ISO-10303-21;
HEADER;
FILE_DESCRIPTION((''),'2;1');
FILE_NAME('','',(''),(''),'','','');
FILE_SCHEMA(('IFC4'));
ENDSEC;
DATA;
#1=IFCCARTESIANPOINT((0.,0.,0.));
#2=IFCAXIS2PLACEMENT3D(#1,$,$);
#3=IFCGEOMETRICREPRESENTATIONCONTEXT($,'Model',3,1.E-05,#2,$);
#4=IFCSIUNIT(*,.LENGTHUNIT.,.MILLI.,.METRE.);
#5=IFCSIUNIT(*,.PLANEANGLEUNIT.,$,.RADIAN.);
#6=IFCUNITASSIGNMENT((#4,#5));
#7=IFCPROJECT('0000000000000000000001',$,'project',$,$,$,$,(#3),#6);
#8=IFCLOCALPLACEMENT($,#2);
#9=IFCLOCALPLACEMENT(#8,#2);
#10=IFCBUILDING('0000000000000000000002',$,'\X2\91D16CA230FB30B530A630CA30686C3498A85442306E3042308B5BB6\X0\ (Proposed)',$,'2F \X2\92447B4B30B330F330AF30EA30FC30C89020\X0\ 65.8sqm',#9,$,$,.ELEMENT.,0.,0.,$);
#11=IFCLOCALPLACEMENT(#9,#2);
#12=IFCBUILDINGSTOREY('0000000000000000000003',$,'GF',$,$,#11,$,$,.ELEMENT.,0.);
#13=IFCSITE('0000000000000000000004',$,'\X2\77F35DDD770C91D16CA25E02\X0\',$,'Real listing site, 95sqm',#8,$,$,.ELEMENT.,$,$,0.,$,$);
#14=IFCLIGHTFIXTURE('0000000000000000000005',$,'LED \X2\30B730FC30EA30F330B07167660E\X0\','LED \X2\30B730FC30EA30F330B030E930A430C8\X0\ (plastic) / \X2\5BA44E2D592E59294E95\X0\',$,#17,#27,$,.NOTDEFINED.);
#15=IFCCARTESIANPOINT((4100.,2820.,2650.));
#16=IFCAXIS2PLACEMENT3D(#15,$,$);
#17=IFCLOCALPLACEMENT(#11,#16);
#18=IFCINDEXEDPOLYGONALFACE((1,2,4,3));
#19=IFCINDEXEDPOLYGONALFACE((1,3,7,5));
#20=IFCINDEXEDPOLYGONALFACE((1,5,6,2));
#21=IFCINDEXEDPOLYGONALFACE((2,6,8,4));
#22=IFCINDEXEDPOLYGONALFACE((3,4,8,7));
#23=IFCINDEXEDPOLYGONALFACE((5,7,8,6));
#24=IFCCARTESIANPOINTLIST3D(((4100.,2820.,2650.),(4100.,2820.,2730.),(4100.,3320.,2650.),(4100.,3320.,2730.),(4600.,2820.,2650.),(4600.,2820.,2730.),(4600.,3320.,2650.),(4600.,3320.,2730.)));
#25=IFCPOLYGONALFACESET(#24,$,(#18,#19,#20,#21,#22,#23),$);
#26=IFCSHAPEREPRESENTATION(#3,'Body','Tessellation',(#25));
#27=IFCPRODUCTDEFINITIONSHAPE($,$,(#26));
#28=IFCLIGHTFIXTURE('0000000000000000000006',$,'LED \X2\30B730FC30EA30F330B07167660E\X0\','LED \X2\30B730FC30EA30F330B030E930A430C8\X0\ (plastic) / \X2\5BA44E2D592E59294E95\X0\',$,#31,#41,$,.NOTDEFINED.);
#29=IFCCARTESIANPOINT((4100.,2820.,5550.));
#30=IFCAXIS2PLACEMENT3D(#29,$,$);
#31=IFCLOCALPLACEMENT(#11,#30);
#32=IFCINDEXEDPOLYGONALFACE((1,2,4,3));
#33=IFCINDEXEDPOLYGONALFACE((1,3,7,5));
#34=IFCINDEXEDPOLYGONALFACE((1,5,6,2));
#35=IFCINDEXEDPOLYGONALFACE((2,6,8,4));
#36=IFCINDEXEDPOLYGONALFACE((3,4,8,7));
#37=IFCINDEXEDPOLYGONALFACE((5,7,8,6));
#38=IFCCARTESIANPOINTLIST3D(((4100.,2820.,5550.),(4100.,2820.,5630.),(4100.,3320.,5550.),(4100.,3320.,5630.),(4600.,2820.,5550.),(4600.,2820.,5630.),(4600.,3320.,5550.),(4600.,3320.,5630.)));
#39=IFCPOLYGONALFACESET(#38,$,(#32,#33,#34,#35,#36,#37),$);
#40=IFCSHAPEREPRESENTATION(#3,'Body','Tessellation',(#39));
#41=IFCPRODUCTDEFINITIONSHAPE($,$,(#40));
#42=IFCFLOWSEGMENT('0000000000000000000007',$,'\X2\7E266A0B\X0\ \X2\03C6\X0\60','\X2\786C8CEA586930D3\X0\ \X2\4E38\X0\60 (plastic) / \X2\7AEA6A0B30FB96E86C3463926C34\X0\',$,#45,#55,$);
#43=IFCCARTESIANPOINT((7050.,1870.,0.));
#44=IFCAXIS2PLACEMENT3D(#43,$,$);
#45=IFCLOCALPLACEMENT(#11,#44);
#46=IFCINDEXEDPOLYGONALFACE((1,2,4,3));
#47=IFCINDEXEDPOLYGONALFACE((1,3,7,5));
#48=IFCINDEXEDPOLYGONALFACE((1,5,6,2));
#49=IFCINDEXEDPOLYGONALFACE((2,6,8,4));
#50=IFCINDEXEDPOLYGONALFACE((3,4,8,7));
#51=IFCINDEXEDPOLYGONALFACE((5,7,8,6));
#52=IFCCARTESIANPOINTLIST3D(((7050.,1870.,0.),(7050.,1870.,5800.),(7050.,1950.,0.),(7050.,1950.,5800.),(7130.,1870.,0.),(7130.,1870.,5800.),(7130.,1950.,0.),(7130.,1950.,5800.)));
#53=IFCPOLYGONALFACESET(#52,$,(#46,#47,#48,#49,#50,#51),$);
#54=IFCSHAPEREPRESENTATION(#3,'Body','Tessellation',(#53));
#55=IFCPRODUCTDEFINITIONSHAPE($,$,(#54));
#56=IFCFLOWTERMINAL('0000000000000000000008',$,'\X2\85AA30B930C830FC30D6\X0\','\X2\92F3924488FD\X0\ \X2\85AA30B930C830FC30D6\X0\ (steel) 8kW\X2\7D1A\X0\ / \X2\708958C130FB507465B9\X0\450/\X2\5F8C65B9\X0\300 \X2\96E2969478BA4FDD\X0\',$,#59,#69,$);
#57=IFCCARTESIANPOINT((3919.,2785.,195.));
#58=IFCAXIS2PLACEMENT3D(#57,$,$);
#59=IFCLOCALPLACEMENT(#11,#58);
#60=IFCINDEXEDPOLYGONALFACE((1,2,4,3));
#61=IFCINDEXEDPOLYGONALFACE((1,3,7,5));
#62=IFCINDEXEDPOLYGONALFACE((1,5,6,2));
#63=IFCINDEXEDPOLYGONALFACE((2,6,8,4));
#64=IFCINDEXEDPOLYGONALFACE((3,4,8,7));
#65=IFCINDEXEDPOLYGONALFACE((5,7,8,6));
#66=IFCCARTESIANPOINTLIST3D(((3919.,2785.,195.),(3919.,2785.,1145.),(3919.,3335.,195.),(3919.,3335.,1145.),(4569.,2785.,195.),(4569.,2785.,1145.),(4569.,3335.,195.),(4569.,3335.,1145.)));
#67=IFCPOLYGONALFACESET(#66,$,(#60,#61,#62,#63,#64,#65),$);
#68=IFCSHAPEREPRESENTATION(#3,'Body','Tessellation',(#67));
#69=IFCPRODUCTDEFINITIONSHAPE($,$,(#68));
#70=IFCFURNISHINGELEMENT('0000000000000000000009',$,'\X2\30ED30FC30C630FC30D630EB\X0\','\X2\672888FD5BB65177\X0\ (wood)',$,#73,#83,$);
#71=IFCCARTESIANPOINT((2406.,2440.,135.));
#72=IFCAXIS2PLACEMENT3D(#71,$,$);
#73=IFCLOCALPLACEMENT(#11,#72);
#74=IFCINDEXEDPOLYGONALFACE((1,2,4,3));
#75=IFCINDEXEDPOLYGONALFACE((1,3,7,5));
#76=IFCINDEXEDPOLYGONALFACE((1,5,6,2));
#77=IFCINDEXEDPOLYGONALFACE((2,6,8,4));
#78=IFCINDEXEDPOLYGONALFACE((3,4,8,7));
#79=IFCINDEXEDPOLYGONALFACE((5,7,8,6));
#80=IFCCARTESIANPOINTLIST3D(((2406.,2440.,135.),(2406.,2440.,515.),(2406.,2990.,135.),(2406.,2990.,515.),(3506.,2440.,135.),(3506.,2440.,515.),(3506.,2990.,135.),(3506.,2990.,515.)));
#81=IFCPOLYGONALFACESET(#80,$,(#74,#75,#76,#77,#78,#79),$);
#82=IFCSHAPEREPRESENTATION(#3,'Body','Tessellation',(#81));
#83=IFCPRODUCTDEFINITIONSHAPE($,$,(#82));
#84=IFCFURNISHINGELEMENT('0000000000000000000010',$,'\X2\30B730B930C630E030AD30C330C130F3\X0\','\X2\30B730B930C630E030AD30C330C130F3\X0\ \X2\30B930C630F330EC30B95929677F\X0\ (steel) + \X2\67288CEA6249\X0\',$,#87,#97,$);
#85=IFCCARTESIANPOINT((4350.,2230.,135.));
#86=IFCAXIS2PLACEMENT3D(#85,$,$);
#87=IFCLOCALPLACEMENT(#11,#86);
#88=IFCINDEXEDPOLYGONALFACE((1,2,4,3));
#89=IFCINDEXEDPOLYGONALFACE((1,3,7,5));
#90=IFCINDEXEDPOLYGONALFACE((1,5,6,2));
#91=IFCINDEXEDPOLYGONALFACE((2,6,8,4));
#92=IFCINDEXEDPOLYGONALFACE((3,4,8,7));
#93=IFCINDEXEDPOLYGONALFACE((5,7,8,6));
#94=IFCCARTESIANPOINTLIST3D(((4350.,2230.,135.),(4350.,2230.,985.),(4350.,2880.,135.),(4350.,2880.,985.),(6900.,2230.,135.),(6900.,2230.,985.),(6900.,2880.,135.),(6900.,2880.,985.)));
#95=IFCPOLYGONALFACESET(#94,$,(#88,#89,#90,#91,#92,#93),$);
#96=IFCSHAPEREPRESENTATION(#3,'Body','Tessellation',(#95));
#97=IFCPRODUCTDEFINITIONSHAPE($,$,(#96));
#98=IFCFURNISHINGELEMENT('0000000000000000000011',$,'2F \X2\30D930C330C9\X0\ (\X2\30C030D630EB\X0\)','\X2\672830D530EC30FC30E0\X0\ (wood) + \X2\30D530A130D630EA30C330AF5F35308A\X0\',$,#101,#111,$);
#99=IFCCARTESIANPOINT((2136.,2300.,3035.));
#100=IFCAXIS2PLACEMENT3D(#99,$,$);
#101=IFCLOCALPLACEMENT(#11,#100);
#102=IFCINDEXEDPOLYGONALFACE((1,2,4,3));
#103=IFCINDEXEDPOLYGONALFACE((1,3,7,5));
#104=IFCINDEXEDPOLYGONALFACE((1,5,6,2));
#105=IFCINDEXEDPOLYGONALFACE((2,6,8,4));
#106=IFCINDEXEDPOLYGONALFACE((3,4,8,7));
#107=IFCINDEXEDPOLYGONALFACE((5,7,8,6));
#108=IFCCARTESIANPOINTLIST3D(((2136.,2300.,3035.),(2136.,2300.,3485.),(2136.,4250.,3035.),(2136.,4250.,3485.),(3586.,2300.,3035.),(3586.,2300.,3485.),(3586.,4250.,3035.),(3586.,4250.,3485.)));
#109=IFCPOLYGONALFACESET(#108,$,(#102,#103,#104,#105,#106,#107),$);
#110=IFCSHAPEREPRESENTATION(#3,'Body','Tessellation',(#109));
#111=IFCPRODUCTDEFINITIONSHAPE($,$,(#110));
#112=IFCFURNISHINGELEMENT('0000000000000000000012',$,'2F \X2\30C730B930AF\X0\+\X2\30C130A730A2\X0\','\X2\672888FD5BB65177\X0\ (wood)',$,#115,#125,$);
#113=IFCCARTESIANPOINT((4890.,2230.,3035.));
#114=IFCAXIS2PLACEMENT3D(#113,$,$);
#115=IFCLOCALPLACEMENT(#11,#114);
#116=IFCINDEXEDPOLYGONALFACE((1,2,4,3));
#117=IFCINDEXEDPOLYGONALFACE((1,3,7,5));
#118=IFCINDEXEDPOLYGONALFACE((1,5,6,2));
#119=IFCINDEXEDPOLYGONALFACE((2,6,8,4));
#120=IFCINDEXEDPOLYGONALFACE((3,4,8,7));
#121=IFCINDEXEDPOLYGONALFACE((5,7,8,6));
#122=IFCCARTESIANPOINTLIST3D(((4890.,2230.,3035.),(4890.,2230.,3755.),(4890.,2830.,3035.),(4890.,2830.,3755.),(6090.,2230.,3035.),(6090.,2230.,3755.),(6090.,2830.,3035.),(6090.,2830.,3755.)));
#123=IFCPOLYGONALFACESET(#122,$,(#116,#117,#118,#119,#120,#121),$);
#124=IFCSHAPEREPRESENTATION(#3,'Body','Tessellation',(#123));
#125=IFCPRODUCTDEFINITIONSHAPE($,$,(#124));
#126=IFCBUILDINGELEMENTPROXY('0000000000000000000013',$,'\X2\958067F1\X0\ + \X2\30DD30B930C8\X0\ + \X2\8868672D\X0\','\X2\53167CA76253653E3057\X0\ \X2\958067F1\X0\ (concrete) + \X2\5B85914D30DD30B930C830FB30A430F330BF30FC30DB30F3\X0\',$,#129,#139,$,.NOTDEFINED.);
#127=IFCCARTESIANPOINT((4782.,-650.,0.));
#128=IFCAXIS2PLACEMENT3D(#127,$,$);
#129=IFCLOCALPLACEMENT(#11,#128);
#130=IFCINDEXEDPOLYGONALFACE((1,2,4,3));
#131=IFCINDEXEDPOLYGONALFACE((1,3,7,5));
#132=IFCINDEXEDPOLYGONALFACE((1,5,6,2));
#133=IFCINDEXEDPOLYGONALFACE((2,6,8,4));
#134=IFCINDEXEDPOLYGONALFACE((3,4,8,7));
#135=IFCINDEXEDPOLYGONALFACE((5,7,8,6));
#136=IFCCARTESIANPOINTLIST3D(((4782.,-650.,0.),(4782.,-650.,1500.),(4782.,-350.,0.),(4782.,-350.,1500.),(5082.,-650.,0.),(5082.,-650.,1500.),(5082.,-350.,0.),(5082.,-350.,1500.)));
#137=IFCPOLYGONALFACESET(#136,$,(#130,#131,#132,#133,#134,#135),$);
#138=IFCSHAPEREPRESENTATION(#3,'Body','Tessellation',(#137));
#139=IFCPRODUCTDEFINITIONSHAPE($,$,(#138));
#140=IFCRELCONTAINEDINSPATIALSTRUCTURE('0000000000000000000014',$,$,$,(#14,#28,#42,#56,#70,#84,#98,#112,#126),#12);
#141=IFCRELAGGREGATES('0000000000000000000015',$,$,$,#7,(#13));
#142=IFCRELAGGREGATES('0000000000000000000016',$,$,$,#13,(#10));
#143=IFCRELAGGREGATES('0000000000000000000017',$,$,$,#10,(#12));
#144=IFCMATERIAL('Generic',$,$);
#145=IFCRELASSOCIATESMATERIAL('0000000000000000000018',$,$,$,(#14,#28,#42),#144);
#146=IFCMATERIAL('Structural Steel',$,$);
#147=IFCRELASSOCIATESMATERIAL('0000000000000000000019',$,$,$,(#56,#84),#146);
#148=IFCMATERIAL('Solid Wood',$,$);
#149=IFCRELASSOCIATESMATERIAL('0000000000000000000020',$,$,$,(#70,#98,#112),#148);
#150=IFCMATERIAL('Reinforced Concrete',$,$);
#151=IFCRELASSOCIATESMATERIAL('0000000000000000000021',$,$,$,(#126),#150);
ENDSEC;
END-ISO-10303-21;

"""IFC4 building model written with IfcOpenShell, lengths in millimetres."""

from ifc_helpers import new_model, si_unit, frame, frame_2d, origin, place, context, project, spatial, rectangle, extrude, material, element, save


model = new_model("IFC4")

# Units and contexts
model_context = context("Model", 3, precision=1e-05, world=origin())
ifc_project = project(units=[si_unit("LENGTHUNIT", "METRE", prefix="MILLI"), si_unit("PLANEANGLEUNIT", "RADIAN")], contexts=[model_context])

# Site, building, storey
site_placement = place(None, origin())
site = spatial("IfcSite", under=ifc_project, at=site_placement, Name="石川県金沢市", ObjectType="Real listing site, 95sqm", CompositionType="ELEMENT", RefElevation=0.0)
building_placement = place(site_placement, origin())
building = spatial("IfcBuilding", under=site, at=building_placement, Name="金沢・サウナと水風呂のある家 (Proposed)", ObjectType="2F 鉄筋コンクリート造 65.8sqm", CompositionType="ELEMENT", ElevationOfRefHeight=0.0, ElevationOfTerrain=0.0)
storey_placement = place(building_placement, origin())
storey = spatial("IfcBuildingStorey", under=building, at=storey_placement, Name="GF", CompositionType="ELEMENT", Elevation=0.0)

# Shared definitions
ifc_material_1 = material(Name="Solid Wood")

# Shared definitions
ifc_material_2 = material(Name="Reinforced Concrete")

# Shared definitions
ifc_material_3 = material(Name="Structural Steel")

# Shared definitions
ifc_material_4 = material(Name="Generic")

# Light fixtures
light_fixture_1_placement = place(storey_placement, frame((4100.0, 2820.0, 2650.0)))
element("IfcLightFixture", 1, at=light_fixture_1_placement, inside=storey, material=ifc_material_4, Name="LED シーリング照明", Description="LED シーリングライト (plastic) / 室中央天井", PredefinedType="NOTDEFINED", context=model_context, shape_type="SweptSolid", body=[
    extrude(rectangle(XDim=500.0, YDim=500.0, at=frame_2d((250.0, 250.0))), frame((4100.0, 2820.0, 2650.0)), (0.0, 0.0, 1.0), 80.0),
])
light_fixture_2_placement = place(storey_placement, frame((4100.0, 2820.0, 5550.0)))
element("IfcLightFixture", 2, at=light_fixture_2_placement, inside=storey, material=ifc_material_4, Name="LED シーリング照明", Description="LED シーリングライト (plastic) / 室中央天井", PredefinedType="NOTDEFINED", context=model_context, shape_type="SweptSolid", body=[
    extrude(rectangle(XDim=500.0, YDim=500.0, at=frame_2d((250.0, 250.0))), frame((4100.0, 2820.0, 5550.0)), (0.0, 0.0, 1.0), 80.0),
])

# Flow segment
flow_segment_placement = place(storey_placement, frame((7050.0, 1870.0, 0.0)))
element("IfcFlowSegment", 3, at=flow_segment_placement, inside=storey, material=ifc_material_4, Name="縦樋 φ60", Description="硬質塩ビ 丸60 (plastic) / 竪樋・雨水排水", context=model_context, shape_type="SweptSolid", body=[
    extrude(rectangle(XDim=80.0, YDim=80.0, at=frame_2d((40.0, 40.0))), frame((7050.0, 1870.0, 0.0)), (0.0, 0.0, 1.0), 5800.0),
])

# Flow terminal
flow_terminal_1_placement = place(storey_placement, frame((3919.0, 2785.0, 195.0)))
element("IfcFlowTerminal", 4, at=flow_terminal_1_placement, inside=storey, material=ifc_material_3, Name="薪ストーブ", Description="鋳鉄製 薪ストーブ (steel) 8kW級 / 炉壁・側方450/後方300 離隔確保", context=model_context, shape_type="SweptSolid", body=[
    extrude(rectangle(XDim=650.0, YDim=550.0, at=frame_2d((325.0, 275.0))), frame((3919.0, 2785.0, 195.0)), (0.0, 0.0, 1.0), 950.0),
])

# Furnishing elements
furnishing_1_placement = place(storey_placement, frame((2406.0, 2440.0, 135.0)))
element("IfcFurnishingElement", 5, at=furnishing_1_placement, inside=storey, material=ifc_material_1, Name="ローテーブル", Description="木製家具 (wood)", context=model_context, shape_type="SweptSolid", body=[
    extrude(rectangle(XDim=1100.0, YDim=550.0, at=frame_2d((550.0, 275.0))), frame((2406.0, 2440.0, 135.0)), (0.0, 0.0, 1.0), 380.0),
])
furnishing_2_placement = place(storey_placement, frame((4350.0, 2230.0, 135.0)))
element("IfcFurnishingElement", 6, at=furnishing_2_placement, inside=storey, material=ifc_material_3, Name="システムキッチン", Description="システムキッチン ステンレス天板 (steel) + 木質扉", context=model_context, shape_type="SweptSolid", body=[
    extrude(rectangle(XDim=2550.0, YDim=650.0, at=frame_2d((1275.0, 325.0))), frame((4350.0, 2230.0, 135.0)), (0.0, 0.0, 1.0), 850.0),
])
furnishing_3_placement = place(storey_placement, frame((2136.0, 2300.0, 3035.0)))
element("IfcFurnishingElement", 7, at=furnishing_3_placement, inside=storey, material=ifc_material_1, Name="2F ベッド (ダブル)", Description="木フレーム (wood) + ファブリック張り", context=model_context, shape_type="SweptSolid", body=[
    extrude(rectangle(XDim=1450.0, YDim=1950.0, at=frame_2d((725.0, 975.0))), frame((2136.0, 2300.0, 3035.0)), (0.0, 0.0, 1.0), 450.0),
])
furnishing_4_placement = place(storey_placement, frame((4890.0, 2230.0, 3035.0)))
element("IfcFurnishingElement", 8, at=furnishing_4_placement, inside=storey, material=ifc_material_1, Name="2F デスク+チェア", Description="木製家具 (wood)", context=model_context, shape_type="SweptSolid", body=[
    extrude(rectangle(XDim=1200.0, YDim=600.0, at=frame_2d((600.0, 300.0))), frame((4890.0, 2230.0, 3035.0)), (0.0, 0.0, 1.0), 720.0),
])

# Building element proxy
proxy_placement = place(storey_placement, frame((4782.0, -650.0, 0.0)))
element("IfcBuildingElementProxy", 9, at=proxy_placement, inside=storey, material=ifc_material_2, Name="門柱 + ポスト + 表札", Description="化粧打放し 門柱 (concrete) + 宅配ポスト・インターホン", PredefinedType="NOTDEFINED", context=model_context, shape_type="SweptSolid", body=[
    extrude(rectangle(XDim=300.0, YDim=300.0, at=frame_2d((150.0, 150.0))), frame((4782.0, -650.0, 0.0)), (0.0, 0.0, 1.0), 1500.0),
])

save(model, "model.ifc")
